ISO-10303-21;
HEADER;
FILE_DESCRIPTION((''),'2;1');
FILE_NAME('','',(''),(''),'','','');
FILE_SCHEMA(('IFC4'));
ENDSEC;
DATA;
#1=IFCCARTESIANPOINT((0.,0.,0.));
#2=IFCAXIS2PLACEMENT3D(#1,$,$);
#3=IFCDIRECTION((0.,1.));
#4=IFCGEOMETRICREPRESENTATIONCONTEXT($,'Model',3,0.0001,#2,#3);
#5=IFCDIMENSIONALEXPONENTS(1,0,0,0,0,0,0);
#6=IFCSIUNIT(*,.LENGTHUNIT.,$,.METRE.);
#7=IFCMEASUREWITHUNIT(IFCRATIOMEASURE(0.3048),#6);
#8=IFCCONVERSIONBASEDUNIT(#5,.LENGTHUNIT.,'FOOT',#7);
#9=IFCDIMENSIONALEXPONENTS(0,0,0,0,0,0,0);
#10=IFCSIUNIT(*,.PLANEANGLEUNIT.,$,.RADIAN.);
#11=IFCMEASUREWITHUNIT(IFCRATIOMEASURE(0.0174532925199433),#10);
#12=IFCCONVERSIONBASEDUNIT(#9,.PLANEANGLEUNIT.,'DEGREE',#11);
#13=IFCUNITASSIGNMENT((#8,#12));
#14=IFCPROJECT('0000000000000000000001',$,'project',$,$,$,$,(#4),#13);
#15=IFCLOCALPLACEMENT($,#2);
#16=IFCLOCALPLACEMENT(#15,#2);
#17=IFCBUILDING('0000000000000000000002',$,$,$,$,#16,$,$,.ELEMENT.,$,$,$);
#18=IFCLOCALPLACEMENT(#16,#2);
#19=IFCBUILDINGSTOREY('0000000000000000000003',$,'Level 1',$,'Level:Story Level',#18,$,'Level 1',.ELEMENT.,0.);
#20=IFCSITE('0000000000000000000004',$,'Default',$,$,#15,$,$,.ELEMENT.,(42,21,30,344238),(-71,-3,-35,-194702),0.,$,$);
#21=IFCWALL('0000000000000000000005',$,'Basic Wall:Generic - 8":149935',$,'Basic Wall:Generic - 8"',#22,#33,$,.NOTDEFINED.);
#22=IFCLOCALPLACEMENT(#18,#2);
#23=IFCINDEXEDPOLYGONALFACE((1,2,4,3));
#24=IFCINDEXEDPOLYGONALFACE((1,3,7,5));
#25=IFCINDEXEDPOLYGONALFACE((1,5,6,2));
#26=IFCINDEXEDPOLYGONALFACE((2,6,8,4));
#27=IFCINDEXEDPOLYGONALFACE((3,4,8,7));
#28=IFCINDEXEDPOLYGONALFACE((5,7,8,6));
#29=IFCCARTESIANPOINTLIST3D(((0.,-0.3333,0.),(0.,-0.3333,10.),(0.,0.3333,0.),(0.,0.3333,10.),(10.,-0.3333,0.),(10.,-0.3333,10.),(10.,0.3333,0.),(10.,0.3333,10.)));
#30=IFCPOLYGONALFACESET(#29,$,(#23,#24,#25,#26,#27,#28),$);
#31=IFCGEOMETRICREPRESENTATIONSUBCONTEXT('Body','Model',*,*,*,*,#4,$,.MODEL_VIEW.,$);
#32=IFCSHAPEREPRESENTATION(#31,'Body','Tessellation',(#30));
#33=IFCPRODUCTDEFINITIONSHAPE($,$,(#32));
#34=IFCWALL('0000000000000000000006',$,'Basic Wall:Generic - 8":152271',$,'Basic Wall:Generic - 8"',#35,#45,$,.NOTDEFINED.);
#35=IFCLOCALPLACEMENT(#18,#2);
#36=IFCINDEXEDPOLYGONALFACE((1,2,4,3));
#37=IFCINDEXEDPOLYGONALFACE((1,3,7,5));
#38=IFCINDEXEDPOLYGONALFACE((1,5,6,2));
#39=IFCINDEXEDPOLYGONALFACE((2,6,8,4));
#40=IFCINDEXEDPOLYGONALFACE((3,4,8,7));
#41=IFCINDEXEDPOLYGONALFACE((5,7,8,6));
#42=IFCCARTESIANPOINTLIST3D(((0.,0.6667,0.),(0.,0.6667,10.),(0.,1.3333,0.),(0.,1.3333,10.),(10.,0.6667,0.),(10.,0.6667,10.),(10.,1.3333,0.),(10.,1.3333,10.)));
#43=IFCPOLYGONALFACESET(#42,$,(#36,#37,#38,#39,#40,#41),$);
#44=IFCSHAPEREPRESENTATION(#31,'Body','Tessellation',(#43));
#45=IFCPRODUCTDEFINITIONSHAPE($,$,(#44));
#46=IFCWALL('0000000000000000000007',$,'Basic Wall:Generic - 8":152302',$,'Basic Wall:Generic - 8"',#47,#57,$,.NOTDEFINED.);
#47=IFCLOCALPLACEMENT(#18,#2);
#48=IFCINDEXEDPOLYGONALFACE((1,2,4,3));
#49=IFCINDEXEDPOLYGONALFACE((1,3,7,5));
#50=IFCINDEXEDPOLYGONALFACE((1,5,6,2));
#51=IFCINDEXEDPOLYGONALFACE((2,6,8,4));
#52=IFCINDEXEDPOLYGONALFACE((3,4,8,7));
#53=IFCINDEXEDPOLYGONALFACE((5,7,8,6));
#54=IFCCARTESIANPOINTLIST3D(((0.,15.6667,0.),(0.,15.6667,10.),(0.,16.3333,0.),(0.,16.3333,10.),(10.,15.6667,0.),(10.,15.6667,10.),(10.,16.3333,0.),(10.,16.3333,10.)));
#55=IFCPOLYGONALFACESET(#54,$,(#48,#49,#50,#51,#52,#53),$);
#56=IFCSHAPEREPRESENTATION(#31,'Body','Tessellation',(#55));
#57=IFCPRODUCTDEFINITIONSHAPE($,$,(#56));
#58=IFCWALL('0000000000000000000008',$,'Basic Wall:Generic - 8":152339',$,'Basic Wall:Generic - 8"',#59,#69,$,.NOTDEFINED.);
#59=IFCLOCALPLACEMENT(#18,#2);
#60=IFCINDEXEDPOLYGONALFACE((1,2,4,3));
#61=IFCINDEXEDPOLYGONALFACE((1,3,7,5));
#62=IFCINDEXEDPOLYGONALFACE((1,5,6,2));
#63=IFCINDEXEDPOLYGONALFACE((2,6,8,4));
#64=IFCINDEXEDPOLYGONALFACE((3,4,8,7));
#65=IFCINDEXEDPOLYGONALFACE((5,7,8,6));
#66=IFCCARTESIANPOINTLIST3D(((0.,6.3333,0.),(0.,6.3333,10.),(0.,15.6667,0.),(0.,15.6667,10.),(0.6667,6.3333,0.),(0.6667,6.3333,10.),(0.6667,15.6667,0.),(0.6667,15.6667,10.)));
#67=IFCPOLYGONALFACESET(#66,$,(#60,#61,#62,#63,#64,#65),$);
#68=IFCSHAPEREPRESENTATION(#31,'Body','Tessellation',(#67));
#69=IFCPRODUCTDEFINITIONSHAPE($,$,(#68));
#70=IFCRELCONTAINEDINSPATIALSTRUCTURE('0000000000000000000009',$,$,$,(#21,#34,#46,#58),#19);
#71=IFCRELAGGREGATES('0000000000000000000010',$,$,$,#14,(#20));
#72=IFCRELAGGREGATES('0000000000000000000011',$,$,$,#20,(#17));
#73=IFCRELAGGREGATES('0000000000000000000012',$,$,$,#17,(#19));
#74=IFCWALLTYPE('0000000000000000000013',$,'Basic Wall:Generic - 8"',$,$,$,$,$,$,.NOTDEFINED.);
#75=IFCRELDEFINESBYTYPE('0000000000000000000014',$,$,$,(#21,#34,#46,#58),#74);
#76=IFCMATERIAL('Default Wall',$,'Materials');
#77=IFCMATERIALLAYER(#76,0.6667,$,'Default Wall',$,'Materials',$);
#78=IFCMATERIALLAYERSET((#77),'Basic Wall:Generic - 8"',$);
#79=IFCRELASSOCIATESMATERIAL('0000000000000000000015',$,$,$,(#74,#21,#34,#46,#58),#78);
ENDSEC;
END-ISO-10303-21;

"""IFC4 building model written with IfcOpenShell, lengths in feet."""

from ifc_helpers import new_model, entity, si_unit, converted_unit, direction, frame, frame_2d, origin, place, context, subcontext, project, spatial, rectangle, extrude, material, layer, layer_set, layer_usage, type_object, element, save


model = new_model("IFC4")

# Units and contexts
model_context = context("Model", 3, precision=0.0001, world=origin(), true_north=direction((0.0, 1.0)))
body_context = subcontext(model_context, "Body", "Model", "MODEL_VIEW")
ifc_project = project(units=[converted_unit("LENGTHUNIT", "FOOT", entity("IfcRatioMeasure", 0.3048), si_unit("LENGTHUNIT", "METRE"), dimensions=[1, 0, 0, 0, 0, 0, 0]), converted_unit("PLANEANGLEUNIT", "DEGREE", entity("IfcRatioMeasure", 0.0174532925199433), si_unit("PLANEANGLEUNIT", "RADIAN"), dimensions=[0, 0, 0, 0, 0, 0, 0])], contexts=[model_context])

# Site, building, storey
site_placement = place(None, origin())
site = spatial("IfcSite", under=ifc_project, at=site_placement, Name="Default", CompositionType="ELEMENT", RefLatitude=(42, 21, 30, 344238), RefLongitude=(-71, -3, -35, -194702), RefElevation=0.0)
building_placement = place(site_placement, origin())
building = spatial("IfcBuilding", under=site, at=building_placement, CompositionType="ELEMENT")
storey_placement = place(building_placement, origin())
storey = spatial("IfcBuildingStorey", under=building, at=storey_placement, Name="Level 1", ObjectType="Level:Story Level", LongName="Level 1", CompositionType="ELEMENT", Elevation=0.0)

# Walls
ifc_material = material(Name="Default Wall", Category="Materials")
ifc_layer = layer(ifc_material, 0.6667, Name="Default Wall", Category="Materials")
ifc_layer_set = layer_set([ifc_layer], Name="Basic Wall:Generic - 8\"")
ifc_layer_usage_1 = layer_usage(ifc_layer_set, "AXIS2", "NEGATIVE", 0.3333)
wall_type = type_object("IfcWallType", Name="Basic Wall:Generic - 8\"", PredefinedType="NOTDEFINED", material=ifc_layer_set)
wall_1_placement = place(storey_placement, origin())
element("IfcWall", 1, at=wall_1_placement, inside=storey, type_object=wall_type, material=ifc_layer_usage_1, Name="Basic Wall:Generic - 8\":149935", ObjectType="Basic Wall:Generic - 8\"", PredefinedType="NOTDEFINED", context=body_context, shape_type="SweptSolid", body=[
    extrude(rectangle(XDim=10.0, YDim=0.6667, at=frame_2d((5.0, 0.0), x_axis=(-1.0, 0.0))), origin(), (0.0, 0.0, 1.0), 10.0),
])
ifc_layer_usage_2 = layer_usage(ifc_layer_set, "AXIS2", "NEGATIVE", 0.3333)
wall_2_placement = place(storey_placement, frame((0.0, 1.0, 0.0)))
element("IfcWall", 2, at=wall_2_placement, inside=storey, type_object=wall_type, material=ifc_layer_usage_2, Name="Basic Wall:Generic - 8\":152271", ObjectType="Basic Wall:Generic - 8\"", PredefinedType="NOTDEFINED", context=body_context, shape_type="SweptSolid", body=[
    extrude(rectangle(XDim=10.0, YDim=0.6667, at=frame_2d((5.0, 0.0), x_axis=(-1.0, 0.0))), origin(), (0.0, 0.0, 1.0), 10.0),
])
ifc_layer_usage_3 = layer_usage(ifc_layer_set, "AXIS2", "NEGATIVE", 0.3333)
wall_3_placement = place(storey_placement, frame((0.0, 16.0, 0.0)))
element("IfcWall", 3, at=wall_3_placement, inside=storey, type_object=wall_type, material=ifc_layer_usage_3, Name="Basic Wall:Generic - 8\":152302", ObjectType="Basic Wall:Generic - 8\"", PredefinedType="NOTDEFINED", context=body_context, shape_type="SweptSolid", body=[
    extrude(rectangle(XDim=10.0, YDim=0.6667, at=frame_2d((5.0, 0.0), x_axis=(-1.0, 0.0))), origin(), (0.0, 0.0, 1.0), 10.0),
])
ifc_layer_usage_4 = layer_usage(ifc_layer_set, "AXIS2", "POSITIVE", -0.3333)
wall_4_placement = place(storey_placement, frame((0.3333, 15.6667, 0.0), z_axis=(0.0, 0.0, 1.0), x_axis=(0.0, -1.0, 0.0)))
element("IfcWall", 4, at=wall_4_placement, inside=storey, type_object=wall_type, material=ifc_layer_usage_4, Name="Basic Wall:Generic - 8\":152339", ObjectType="Basic Wall:Generic - 8\"", PredefinedType="NOTDEFINED", context=body_context, shape_type="SweptSolid", body=[
    extrude(rectangle(XDim=9.3333, YDim=0.6667, at=frame_2d((4.6667, 0.0), x_axis=(-1.0, 0.0))), origin(), (0.0, 0.0, 1.0), 10.0),
])

save(model, "model.ifc")
